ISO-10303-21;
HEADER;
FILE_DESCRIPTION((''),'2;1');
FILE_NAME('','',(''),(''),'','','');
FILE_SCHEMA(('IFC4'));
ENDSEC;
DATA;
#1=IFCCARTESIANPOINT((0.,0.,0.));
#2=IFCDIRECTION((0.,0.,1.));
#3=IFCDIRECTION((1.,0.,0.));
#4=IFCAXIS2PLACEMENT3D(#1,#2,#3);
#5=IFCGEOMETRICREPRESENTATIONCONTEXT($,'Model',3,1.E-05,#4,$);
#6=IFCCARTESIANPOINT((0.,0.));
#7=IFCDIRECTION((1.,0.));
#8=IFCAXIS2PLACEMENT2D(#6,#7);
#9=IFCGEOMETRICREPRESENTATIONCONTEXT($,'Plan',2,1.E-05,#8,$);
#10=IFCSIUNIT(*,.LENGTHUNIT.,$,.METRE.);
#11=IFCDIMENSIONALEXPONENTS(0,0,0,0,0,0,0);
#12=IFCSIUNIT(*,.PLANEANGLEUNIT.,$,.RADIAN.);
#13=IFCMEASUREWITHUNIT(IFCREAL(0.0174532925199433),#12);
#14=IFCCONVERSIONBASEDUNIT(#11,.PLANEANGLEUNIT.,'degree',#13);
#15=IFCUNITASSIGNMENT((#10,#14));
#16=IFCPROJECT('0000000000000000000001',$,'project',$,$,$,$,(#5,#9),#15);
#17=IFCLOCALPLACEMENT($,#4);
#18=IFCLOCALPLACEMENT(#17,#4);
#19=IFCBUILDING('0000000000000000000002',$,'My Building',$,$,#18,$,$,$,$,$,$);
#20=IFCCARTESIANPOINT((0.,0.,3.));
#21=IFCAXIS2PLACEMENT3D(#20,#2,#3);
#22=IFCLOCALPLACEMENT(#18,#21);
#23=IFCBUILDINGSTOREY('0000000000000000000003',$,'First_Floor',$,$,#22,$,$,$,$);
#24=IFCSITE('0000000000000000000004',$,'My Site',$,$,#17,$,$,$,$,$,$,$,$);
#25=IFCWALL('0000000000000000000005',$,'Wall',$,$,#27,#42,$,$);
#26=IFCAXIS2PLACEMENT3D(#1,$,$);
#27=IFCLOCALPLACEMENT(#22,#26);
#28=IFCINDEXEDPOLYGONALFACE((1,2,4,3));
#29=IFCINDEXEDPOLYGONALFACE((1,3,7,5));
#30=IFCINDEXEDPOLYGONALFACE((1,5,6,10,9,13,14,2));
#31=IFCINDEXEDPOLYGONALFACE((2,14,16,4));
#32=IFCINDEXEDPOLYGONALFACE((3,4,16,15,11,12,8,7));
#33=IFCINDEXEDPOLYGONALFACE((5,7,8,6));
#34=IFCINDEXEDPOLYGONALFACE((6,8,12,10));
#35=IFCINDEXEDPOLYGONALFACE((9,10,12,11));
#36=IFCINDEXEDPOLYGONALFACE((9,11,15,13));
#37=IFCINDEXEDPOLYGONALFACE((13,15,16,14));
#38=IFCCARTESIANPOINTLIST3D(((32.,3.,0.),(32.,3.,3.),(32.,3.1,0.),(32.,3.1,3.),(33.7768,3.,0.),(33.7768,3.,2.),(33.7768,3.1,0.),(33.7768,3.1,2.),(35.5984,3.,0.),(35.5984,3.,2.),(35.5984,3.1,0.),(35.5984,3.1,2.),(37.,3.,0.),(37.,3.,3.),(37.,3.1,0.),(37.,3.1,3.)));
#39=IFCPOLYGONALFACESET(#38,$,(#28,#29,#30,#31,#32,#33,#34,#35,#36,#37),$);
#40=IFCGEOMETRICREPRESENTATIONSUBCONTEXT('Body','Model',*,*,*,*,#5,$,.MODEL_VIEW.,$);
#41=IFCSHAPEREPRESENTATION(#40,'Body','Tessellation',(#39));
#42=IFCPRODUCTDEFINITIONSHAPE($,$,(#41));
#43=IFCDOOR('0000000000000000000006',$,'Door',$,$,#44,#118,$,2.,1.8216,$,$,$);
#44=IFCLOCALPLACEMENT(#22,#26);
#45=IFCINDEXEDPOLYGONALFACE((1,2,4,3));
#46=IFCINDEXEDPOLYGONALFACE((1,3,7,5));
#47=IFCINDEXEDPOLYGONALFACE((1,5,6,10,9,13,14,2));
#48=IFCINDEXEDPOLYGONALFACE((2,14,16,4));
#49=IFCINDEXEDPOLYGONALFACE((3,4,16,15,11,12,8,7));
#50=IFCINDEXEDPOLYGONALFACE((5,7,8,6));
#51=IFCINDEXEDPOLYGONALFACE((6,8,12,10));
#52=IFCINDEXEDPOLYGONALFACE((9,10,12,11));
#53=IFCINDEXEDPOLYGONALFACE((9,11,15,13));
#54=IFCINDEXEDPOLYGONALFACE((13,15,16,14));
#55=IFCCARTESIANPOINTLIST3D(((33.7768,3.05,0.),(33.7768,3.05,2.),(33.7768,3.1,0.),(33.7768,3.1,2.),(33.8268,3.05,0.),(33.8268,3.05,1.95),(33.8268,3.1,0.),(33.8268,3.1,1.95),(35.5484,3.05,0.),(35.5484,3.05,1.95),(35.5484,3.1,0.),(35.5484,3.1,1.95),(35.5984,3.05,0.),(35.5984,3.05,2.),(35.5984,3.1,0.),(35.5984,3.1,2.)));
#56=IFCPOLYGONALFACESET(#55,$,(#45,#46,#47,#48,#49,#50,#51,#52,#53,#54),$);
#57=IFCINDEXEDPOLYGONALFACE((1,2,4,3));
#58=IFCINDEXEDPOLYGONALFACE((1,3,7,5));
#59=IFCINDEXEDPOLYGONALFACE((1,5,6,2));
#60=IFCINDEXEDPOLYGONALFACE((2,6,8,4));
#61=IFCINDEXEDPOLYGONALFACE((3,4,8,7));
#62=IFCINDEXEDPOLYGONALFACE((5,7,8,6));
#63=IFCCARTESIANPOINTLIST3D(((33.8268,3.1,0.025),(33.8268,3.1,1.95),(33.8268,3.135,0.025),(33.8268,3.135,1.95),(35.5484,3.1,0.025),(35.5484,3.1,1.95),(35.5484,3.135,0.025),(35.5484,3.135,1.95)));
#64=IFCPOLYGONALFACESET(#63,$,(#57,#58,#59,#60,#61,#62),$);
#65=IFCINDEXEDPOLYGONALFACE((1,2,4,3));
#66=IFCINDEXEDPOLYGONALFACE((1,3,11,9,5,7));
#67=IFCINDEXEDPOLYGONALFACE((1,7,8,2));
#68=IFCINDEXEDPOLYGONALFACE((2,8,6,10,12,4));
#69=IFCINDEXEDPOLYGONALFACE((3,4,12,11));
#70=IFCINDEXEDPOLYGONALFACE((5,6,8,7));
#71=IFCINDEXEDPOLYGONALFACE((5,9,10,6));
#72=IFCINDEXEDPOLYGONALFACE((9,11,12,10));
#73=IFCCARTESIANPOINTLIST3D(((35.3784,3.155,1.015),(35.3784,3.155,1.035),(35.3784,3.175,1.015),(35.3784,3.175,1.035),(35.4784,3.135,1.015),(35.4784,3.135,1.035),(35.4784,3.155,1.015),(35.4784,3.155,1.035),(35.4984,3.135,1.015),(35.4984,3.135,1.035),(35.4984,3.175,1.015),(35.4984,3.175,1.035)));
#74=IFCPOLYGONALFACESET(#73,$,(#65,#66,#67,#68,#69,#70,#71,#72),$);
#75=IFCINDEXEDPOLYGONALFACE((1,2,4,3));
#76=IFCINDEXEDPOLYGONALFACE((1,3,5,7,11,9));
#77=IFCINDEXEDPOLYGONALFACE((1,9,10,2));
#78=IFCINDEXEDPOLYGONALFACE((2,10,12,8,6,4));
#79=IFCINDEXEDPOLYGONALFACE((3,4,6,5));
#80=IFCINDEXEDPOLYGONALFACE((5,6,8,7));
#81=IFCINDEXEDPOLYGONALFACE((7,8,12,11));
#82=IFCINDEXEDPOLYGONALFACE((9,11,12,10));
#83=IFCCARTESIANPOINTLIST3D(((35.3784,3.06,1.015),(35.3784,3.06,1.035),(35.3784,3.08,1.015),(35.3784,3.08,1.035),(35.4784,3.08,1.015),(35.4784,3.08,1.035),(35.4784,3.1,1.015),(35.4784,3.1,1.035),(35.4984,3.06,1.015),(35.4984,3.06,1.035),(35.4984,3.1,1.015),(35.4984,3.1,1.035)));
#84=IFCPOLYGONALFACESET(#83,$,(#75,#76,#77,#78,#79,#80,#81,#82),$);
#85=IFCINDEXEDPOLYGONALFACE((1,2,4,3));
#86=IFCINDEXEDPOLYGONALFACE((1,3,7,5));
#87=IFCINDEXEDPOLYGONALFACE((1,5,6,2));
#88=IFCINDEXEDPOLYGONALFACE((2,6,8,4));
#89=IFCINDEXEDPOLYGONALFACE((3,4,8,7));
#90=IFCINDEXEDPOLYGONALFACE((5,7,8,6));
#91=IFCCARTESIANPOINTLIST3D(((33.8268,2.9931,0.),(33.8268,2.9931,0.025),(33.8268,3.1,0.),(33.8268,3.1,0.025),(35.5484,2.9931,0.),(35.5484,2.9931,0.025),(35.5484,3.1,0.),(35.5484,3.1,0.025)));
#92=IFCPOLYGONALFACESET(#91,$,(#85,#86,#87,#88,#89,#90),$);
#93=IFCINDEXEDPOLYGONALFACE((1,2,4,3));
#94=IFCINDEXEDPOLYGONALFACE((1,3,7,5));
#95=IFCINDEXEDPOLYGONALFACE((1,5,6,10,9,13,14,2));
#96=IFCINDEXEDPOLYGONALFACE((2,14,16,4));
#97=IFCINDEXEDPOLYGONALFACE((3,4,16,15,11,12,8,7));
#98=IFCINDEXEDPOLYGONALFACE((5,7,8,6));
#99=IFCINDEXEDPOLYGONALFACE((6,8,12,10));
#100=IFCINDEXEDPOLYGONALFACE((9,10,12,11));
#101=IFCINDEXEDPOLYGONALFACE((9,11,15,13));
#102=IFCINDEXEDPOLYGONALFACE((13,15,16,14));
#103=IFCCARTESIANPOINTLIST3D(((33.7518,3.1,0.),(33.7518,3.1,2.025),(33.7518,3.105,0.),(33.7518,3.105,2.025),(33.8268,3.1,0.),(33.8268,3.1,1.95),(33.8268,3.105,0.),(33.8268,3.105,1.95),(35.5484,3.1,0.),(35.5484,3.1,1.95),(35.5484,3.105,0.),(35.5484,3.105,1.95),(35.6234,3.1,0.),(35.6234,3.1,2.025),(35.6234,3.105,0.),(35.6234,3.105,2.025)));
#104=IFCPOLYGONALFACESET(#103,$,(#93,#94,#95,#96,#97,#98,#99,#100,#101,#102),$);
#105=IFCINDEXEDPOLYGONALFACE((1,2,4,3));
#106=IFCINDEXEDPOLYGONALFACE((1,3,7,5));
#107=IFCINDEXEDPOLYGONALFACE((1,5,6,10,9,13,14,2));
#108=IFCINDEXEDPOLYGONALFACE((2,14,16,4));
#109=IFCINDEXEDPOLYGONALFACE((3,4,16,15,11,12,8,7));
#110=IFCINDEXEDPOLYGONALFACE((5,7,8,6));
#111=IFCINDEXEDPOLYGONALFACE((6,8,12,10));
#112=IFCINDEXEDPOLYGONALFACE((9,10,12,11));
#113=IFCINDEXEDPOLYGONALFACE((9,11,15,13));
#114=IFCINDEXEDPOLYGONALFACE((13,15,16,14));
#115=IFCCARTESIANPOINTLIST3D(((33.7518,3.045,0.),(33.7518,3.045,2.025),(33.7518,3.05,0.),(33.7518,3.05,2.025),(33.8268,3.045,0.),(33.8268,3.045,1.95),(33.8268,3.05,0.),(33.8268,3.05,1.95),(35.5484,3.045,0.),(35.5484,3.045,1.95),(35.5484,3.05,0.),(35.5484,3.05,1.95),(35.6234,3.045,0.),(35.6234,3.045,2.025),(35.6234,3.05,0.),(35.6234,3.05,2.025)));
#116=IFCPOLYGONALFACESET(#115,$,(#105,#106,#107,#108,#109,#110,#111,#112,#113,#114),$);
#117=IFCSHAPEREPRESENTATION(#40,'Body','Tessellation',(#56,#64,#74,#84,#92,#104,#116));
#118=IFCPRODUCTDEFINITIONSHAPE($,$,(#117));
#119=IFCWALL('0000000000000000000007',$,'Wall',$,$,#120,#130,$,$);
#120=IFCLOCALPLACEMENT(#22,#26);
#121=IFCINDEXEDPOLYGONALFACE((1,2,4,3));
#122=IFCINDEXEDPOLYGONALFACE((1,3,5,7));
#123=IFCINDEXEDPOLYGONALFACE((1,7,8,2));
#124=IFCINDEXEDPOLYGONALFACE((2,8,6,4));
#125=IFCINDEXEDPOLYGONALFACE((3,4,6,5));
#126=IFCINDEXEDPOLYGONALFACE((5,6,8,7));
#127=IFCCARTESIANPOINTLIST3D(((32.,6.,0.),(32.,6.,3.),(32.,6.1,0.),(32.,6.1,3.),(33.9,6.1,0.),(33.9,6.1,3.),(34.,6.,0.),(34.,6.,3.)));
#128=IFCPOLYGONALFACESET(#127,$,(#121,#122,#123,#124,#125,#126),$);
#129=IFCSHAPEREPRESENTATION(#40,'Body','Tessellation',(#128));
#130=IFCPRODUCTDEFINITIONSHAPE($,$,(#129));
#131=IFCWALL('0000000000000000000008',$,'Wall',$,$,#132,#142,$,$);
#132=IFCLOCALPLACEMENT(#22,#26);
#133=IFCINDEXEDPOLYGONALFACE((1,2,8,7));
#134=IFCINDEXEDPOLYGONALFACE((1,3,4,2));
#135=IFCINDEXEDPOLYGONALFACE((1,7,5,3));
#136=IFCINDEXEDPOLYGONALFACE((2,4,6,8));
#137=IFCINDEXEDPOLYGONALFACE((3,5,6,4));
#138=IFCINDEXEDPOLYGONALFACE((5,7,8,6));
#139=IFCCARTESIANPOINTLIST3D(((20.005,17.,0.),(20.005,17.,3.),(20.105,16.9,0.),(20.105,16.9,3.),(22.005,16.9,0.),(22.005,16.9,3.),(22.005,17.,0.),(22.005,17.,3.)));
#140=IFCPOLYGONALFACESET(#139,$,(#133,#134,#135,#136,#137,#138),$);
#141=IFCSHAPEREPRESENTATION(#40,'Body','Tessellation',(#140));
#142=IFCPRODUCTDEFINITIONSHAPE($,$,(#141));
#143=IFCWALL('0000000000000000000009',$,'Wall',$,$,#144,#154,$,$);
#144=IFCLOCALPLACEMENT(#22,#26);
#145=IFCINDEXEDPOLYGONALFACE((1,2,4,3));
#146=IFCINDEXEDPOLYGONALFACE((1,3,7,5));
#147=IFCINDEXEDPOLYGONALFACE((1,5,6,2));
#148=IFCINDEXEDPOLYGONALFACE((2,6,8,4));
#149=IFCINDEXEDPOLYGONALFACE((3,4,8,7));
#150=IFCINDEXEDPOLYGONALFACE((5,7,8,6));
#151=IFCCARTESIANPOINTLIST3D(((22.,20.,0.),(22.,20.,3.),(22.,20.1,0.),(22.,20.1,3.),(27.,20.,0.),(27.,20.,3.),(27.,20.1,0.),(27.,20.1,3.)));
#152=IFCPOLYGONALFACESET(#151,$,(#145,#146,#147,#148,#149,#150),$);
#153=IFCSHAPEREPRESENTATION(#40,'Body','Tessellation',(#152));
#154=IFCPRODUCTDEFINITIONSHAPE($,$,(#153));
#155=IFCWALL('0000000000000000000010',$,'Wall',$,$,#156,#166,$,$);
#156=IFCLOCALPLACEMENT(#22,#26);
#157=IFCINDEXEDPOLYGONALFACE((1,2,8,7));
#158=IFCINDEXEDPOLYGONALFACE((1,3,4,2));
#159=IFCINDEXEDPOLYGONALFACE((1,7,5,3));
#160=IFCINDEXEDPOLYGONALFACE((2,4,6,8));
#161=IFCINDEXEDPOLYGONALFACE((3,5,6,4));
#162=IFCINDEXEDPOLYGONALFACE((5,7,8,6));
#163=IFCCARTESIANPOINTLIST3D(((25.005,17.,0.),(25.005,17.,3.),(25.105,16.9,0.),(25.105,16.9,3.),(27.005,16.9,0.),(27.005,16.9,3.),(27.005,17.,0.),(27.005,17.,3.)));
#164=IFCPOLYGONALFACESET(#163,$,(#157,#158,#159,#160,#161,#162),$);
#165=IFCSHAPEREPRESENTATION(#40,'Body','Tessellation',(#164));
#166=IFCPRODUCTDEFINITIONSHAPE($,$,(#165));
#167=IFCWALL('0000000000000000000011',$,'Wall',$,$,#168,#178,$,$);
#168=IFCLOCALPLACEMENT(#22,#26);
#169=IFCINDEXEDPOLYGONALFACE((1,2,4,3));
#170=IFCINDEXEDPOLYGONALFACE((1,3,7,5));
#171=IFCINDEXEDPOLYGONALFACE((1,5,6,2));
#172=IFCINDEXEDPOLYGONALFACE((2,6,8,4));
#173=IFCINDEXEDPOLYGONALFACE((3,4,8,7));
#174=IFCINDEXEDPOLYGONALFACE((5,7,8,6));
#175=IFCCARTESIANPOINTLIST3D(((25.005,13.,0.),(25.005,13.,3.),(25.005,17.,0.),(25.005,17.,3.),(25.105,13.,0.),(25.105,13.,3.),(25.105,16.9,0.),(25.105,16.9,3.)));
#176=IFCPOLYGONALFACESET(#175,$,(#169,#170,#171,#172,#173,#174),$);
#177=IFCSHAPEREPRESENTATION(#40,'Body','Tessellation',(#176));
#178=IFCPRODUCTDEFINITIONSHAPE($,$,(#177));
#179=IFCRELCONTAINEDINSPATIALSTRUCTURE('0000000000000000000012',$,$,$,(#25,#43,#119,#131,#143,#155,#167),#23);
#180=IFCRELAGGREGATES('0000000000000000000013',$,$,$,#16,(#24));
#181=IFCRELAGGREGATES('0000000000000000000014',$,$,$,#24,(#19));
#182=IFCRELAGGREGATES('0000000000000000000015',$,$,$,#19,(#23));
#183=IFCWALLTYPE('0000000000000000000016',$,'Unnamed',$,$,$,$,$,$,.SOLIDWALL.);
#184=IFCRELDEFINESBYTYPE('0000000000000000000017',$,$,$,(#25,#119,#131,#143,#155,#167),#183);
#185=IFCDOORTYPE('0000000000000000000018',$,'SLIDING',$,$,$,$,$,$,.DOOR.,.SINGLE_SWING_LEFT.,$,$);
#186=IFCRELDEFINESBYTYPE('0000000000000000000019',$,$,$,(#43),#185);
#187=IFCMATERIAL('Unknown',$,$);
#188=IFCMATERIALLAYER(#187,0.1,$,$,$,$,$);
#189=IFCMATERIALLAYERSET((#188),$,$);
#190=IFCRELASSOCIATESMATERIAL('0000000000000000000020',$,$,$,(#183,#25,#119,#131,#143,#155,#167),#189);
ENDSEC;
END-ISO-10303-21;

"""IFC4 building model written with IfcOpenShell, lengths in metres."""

from ifc_helpers import new_model, entity, si_unit, converted_unit, frame, origin_with_axes, origin_2d_with_axis, place, context, subcontext, project, spatial, line, indexed_curve, outline, extrude, shape, source, transform, mapped, material, layer, layer_set, layer_usage, type_object, type_shapes, element, fill, save


model = new_model("IFC4")

# Units and contexts
model_context = context("Model", 3, precision=1e-05, world=origin_with_axes())
plan_context = context("Plan", 2, precision=1e-05, world=origin_2d_with_axis())
body_context_1 = subcontext(model_context, "Body", "Model", "MODEL_VIEW")
body_context_2 = subcontext(plan_context, "Body", "Plan", "PLAN_VIEW")
ifc_project = project(units=[si_unit("LENGTHUNIT", "METRE"), converted_unit("PLANEANGLEUNIT", "degree", entity("IfcReal", 0.0174532925199433), si_unit("PLANEANGLEUNIT", "RADIAN"), dimensions=[0, 0, 0, 0, 0, 0, 0])], contexts=[model_context, plan_context])

# Site, building, storey
site_placement = place(None, origin_with_axes())
site = spatial("IfcSite", under=ifc_project, at=site_placement, Name="My Site")
building_placement = place(site_placement, origin_with_axes())
building = spatial("IfcBuilding", under=site, at=building_placement, Name="My Building")
storey_placement = place(building_placement, frame((0.0, 0.0, 3.0), z_axis=(0.0, 0.0, 1.0), x_axis=(1.0, 0.0, 0.0)))
storey = spatial("IfcBuildingStorey", under=building, at=storey_placement, Name="First_Floor")

# Shared definitions
ifc_material = material(Name="Unknown")
ifc_layer = layer(ifc_material, 0.1)
ifc_layer_set = layer_set([ifc_layer])
wall_type = type_object("IfcWallType", Name="Unnamed", PredefinedType="SOLIDWALL", material=ifc_layer_set)
shared_shape_1 = source(origin_with_axes(), body_context_1, "Body", "SweptSolid", [
    extrude(outline(indexed_curve([(0.0, 0.0), (1.8216, 0.0), (1.8216, 2.0), (0.0, 2.0)], segments=[line(1, 2, 3, 4, 1)])), frame((0.0, -0.6, 0.0), z_axis=(0.0, -1.0, 0.0), x_axis=(1.0, 0.0, 0.0)), (0.0, 0.0, -1.0), 1.2),
])
door_type = type_object("IfcDoorType", Name="SLIDING", OperationType="SINGLE_SWING_LEFT", PredefinedType="DOOR")
shared_shape_2 = source(origin_with_axes(), body_context_1, "Body", "SweptSolid", [
    extrude(outline(indexed_curve([(0.0, 0.0), (0.0, 2.0), (1.8216, 2.0), (1.8216, 0.0), (1.7716, 0.0), (1.7716, 1.95), (0.05, 1.95), (0.05, 0.0)], segments=[line(1, 2, 3, 4, 5, 6, 7, 8, 1)])), frame((0.0, 0.0, 0.0), z_axis=(0.0, -1.0, 0.0), x_axis=(1.0, 0.0, 0.0)), (0.0, 0.0, -1.0), 0.05),
    extrude(outline(indexed_curve([(0.0, 0.0), (1.7216, 0.0), (1.7216, 0.035), (0.0, 0.035)], segments=[line(1, 2, 3, 4, 1)])), frame((0.05, -0.035, 0.025), z_axis=(0.0, 0.0, 1.0), x_axis=(1.0, 0.0, 0.0)), (0.0, 0.0, 1.0), 1.925),
    extrude(outline(indexed_curve([(0.0, 0.0), (0.0, -0.04), (0.12, -0.04), (0.12, -0.02), (0.02, -0.02), (0.02, 0.0)], segments=[line(1, 2, 3, 4, 5, 6, 1)])), frame((0.1, -0.035, 1.015), z_axis=(0.0, 0.0, 1.0), x_axis=(1.0, 0.0, 0.0)), (0.0, 0.0, 1.0), 0.02),
    extrude(outline(indexed_curve([(0.0, 0.0), (0.0, 0.04), (0.12, 0.04), (0.12, 0.02), (0.02, 0.02), (0.02, 0.0)], segments=[line(1, 2, 3, 4, 5, 6, 1)])), frame((0.1, 0.0, 1.015), z_axis=(0.0, 0.0, 1.0), x_axis=(1.0, 0.0, 0.0)), (0.0, 0.0, 1.0), 0.02),
    extrude(outline(indexed_curve([(0.0, 0.0), (1.7216, 0.0), (1.7216, 0.1069), (0.0, 0.1069)], segments=[line(1, 2, 3, 4, 1)])), frame((0.05, 0.0, 0.0), z_axis=(0.0, 0.0, 1.0), x_axis=(1.0, 0.0, 0.0)), (0.0, 0.0, 1.0), 0.025),
    extrude(outline(indexed_curve([(0.0, 0.0), (0.0, 2.025), (1.8716, 2.025), (1.8716, 0.0), (1.7966, 0.0), (1.7966, 1.95), (0.075, 1.95), (0.075, 0.0)], segments=[line(1, 2, 3, 4, 5, 6, 7, 8, 1)])), frame((-0.025, -0.005, 0.0), z_axis=(0.0, -1.0, 0.0), x_axis=(1.0, 0.0, 0.0)), (0.0, 0.0, -1.0), 0.005),
    extrude(outline(indexed_curve([(0.0, 0.0), (0.0, 2.025), (1.8716, 2.025), (1.8716, 0.0), (1.7966, 0.0), (1.7966, 1.95), (0.075, 1.95), (0.075, 0.0)], segments=[line(1, 2, 3, 4, 5, 6, 7, 8, 1)])), frame((-0.025, 0.05, 0.0), z_axis=(0.0, -1.0, 0.0), x_axis=(1.0, 0.0, 0.0)), (0.0, 0.0, -1.0), 0.005),
])
shared_shape_3 = source(origin_with_axes(), body_context_2, "Body", "Curve2D", [
    entity("IfcIndexedPolyCurve", entity("IfcCartesianPointList2D", [[0.0, 0.0], [0.05, 0.0], [0.05, 0.05], [0.0, 0.05]]), [entity("IfcLineIndex", [1, 2, 3, 4, 1])]),
    entity("IfcIndexedPolyCurve", entity("IfcCartesianPointList2D", [[1.8216, 0.0], [1.7716, 0.0], [1.7716, 0.05], [1.8216, 0.05]]), [entity("IfcLineIndex", [1, 2, 3, 4, 1])]),
    entity("IfcIndexedPolyCurve", entity("IfcCartesianPointList2D", [[2.6325, -0.035], [0.9108, -0.035], [0.9108, 0.0], [2.6325, 0.0]]), [entity("IfcLineIndex", [1, 2, 3, 4, 1])]),
])
type_shapes(door_type, [shared_shape_2, shared_shape_3])

# Wall, opening, door
ifc_layer_usage_1 = layer_usage(ifc_layer_set, "AXIS2", "POSITIVE", 0.0)
wall_1_placement = place(storey_placement, frame((32.0, 3.0, 0.0), z_axis=(0.0, 0.0, 1.0), x_axis=(1.0, 0.0, 0.0)))
wall_1 = element("IfcWall", 1, at=wall_1_placement, inside=storey, type_object=wall_type, material=ifc_layer_usage_1, Name="Wall", context=body_context_1, shape_type="SweptSolid", body=[
    extrude(outline(indexed_curve([(0.0, 0.0), (0.0, 0.1), (5.0, 0.1), (5.0, 0.0)], segments=[line(1, 2, 3, 4, 1)])), origin_with_axes(), (0.0, 0.0, 1.0), 3.0),
])
opening_1_placement = place(wall_1_placement, frame((3.5984, 0.1, 0.0), z_axis=(0.0, 0.0, 1.0), x_axis=(-1.0, 0.0, 0.0)))
opening_1 = element("IfcOpeningElement", 2, at=opening_1_placement, cuts=wall_1, PredefinedType="OPENING", context=body_context_1, shape_type="MappedRepresentation", body=[
    mapped(shared_shape_1, transform((0.0, 0.0, 0.0), x_axis=(1.0, 0.0, 0.0), y_axis=(0.0, 1.0, 0.0), z_axis=(0.0, 0.0, 1.0), scale=1.0)),
])
door_1_placement = place(opening_1_placement, origin_with_axes())
door_1 = element("IfcDoor", 3, at=door_1_placement, inside=storey, type_object=door_type, Name="Door", OverallHeight=2.0, OverallWidth=1.8216, shapes=[
    shape(body_context_1, "Body", "MappedRepresentation", [mapped(shared_shape_2, transform((0.0, 0.0, 0.0), x_axis=(1.0, 0.0, 0.0), y_axis=(0.0, 1.0, 0.0), z_axis=(0.0, 0.0, 1.0), scale=1.0))]),
    shape(body_context_2, "Body", "MappedRepresentation", [mapped(shared_shape_3, transform((0.0, 0.0, 0.0), x_axis=(1.0, 0.0, 0.0), y_axis=(0.0, 1.0, 0.0), z_axis=(0.0, 0.0, 1.0), scale=1.0))]),
])
fill(opening_1, door_1)

# Walls
ifc_layer_usage_2 = layer_usage(ifc_layer_set, "AXIS2", "POSITIVE", 0.0)
wall_2_placement = place(storey_placement, frame((32.0, 6.0, 0.0), z_axis=(0.0, 0.0, 1.0), x_axis=(1.0, 0.0, 0.0)))
element("IfcWall", 4, at=wall_2_placement, inside=storey, type_object=wall_type, material=ifc_layer_usage_2, Name="Wall", context=body_context_1, shape_type="SweptSolid", body=[
    extrude(outline(indexed_curve([(0.0, 0.0), (0.0, 0.1), (1.9, 0.1), (2.0, 0.0)], segments=[line(1, 2, 3, 4, 1)])), origin_with_axes(), (0.0, 0.0, 1.0), 3.0),
])
ifc_layer_usage_3 = layer_usage(ifc_layer_set, "AXIS2", "POSITIVE", 0.0)
wall_3_placement = place(storey_placement, frame((22.005, 17.0, 0.0), z_axis=(0.0, 0.0, 1.0), x_axis=(-1.0, 0.0, 0.0)))
element("IfcWall", 5, at=wall_3_placement, inside=storey, type_object=wall_type, material=ifc_layer_usage_3, Name="Wall", context=body_context_1, shape_type="SweptSolid", body=[
    extrude(outline(indexed_curve([(0.0, 0.0), (0.0, 0.1), (1.9, 0.1), (2.0, 0.0)], segments=[line(1, 2, 3, 4, 1)])), origin_with_axes(), (0.0, 0.0, 1.0), 3.0),
])
ifc_layer_usage_4 = layer_usage(ifc_layer_set, "AXIS2", "POSITIVE", 0.0)
wall_4_placement = place(storey_placement, frame((22.0, 20.0, 0.0), z_axis=(0.0, 0.0, 1.0), x_axis=(1.0, 0.0, 0.0)))
element("IfcWall", 6, at=wall_4_placement, inside=storey, type_object=wall_type, material=ifc_layer_usage_4, Name="Wall", context=body_context_1, shape_type="SweptSolid", body=[
    extrude(outline(indexed_curve([(0.0, 0.0), (0.0, 0.1), (5.0, 0.1), (5.0, 0.0)], segments=[line(1, 2, 3, 4, 1)])), origin_with_axes(), (0.0, 0.0, 1.0), 3.0),
])
ifc_layer_usage_5 = layer_usage(ifc_layer_set, "AXIS2", "POSITIVE", 0.0)
wall_5_placement = place(storey_placement, frame((27.005, 17.0, 0.0), z_axis=(0.0, 0.0, 1.0), x_axis=(-1.0, 0.0, 0.0)))
element("IfcWall", 7, at=wall_5_placement, inside=storey, type_object=wall_type, material=ifc_layer_usage_5, Name="Wall", context=body_context_1, shape_type="SweptSolid", body=[
    extrude(outline(indexed_curve([(0.0, 0.0), (0.0, 0.1), (1.9, 0.1), (2.0, 0.0)], segments=[line(1, 2, 3, 4, 1)])), origin_with_axes(), (0.0, 0.0, 1.0), 3.0),
])
ifc_layer_usage_6 = layer_usage(ifc_layer_set, "AXIS2", "POSITIVE", 0.0)
wall_6_placement = place(storey_placement, frame((25.005, 17.0, 0.0), z_axis=(0.0, 0.0, 1.0), x_axis=(0.0, -1.0, 0.0)))
element("IfcWall", 8, at=wall_6_placement, inside=storey, type_object=wall_type, material=ifc_layer_usage_6, Name="Wall", context=body_context_1, shape_type="SweptSolid", body=[
    extrude(outline(indexed_curve([(0.0, 0.0), (0.1, 0.1), (4.0, 0.1), (4.0, 0.0)], segments=[line(1, 2, 3, 4, 1)])), origin_with_axes(), (0.0, 0.0, 1.0), 3.0),
])

save(model, "model.ifc")
